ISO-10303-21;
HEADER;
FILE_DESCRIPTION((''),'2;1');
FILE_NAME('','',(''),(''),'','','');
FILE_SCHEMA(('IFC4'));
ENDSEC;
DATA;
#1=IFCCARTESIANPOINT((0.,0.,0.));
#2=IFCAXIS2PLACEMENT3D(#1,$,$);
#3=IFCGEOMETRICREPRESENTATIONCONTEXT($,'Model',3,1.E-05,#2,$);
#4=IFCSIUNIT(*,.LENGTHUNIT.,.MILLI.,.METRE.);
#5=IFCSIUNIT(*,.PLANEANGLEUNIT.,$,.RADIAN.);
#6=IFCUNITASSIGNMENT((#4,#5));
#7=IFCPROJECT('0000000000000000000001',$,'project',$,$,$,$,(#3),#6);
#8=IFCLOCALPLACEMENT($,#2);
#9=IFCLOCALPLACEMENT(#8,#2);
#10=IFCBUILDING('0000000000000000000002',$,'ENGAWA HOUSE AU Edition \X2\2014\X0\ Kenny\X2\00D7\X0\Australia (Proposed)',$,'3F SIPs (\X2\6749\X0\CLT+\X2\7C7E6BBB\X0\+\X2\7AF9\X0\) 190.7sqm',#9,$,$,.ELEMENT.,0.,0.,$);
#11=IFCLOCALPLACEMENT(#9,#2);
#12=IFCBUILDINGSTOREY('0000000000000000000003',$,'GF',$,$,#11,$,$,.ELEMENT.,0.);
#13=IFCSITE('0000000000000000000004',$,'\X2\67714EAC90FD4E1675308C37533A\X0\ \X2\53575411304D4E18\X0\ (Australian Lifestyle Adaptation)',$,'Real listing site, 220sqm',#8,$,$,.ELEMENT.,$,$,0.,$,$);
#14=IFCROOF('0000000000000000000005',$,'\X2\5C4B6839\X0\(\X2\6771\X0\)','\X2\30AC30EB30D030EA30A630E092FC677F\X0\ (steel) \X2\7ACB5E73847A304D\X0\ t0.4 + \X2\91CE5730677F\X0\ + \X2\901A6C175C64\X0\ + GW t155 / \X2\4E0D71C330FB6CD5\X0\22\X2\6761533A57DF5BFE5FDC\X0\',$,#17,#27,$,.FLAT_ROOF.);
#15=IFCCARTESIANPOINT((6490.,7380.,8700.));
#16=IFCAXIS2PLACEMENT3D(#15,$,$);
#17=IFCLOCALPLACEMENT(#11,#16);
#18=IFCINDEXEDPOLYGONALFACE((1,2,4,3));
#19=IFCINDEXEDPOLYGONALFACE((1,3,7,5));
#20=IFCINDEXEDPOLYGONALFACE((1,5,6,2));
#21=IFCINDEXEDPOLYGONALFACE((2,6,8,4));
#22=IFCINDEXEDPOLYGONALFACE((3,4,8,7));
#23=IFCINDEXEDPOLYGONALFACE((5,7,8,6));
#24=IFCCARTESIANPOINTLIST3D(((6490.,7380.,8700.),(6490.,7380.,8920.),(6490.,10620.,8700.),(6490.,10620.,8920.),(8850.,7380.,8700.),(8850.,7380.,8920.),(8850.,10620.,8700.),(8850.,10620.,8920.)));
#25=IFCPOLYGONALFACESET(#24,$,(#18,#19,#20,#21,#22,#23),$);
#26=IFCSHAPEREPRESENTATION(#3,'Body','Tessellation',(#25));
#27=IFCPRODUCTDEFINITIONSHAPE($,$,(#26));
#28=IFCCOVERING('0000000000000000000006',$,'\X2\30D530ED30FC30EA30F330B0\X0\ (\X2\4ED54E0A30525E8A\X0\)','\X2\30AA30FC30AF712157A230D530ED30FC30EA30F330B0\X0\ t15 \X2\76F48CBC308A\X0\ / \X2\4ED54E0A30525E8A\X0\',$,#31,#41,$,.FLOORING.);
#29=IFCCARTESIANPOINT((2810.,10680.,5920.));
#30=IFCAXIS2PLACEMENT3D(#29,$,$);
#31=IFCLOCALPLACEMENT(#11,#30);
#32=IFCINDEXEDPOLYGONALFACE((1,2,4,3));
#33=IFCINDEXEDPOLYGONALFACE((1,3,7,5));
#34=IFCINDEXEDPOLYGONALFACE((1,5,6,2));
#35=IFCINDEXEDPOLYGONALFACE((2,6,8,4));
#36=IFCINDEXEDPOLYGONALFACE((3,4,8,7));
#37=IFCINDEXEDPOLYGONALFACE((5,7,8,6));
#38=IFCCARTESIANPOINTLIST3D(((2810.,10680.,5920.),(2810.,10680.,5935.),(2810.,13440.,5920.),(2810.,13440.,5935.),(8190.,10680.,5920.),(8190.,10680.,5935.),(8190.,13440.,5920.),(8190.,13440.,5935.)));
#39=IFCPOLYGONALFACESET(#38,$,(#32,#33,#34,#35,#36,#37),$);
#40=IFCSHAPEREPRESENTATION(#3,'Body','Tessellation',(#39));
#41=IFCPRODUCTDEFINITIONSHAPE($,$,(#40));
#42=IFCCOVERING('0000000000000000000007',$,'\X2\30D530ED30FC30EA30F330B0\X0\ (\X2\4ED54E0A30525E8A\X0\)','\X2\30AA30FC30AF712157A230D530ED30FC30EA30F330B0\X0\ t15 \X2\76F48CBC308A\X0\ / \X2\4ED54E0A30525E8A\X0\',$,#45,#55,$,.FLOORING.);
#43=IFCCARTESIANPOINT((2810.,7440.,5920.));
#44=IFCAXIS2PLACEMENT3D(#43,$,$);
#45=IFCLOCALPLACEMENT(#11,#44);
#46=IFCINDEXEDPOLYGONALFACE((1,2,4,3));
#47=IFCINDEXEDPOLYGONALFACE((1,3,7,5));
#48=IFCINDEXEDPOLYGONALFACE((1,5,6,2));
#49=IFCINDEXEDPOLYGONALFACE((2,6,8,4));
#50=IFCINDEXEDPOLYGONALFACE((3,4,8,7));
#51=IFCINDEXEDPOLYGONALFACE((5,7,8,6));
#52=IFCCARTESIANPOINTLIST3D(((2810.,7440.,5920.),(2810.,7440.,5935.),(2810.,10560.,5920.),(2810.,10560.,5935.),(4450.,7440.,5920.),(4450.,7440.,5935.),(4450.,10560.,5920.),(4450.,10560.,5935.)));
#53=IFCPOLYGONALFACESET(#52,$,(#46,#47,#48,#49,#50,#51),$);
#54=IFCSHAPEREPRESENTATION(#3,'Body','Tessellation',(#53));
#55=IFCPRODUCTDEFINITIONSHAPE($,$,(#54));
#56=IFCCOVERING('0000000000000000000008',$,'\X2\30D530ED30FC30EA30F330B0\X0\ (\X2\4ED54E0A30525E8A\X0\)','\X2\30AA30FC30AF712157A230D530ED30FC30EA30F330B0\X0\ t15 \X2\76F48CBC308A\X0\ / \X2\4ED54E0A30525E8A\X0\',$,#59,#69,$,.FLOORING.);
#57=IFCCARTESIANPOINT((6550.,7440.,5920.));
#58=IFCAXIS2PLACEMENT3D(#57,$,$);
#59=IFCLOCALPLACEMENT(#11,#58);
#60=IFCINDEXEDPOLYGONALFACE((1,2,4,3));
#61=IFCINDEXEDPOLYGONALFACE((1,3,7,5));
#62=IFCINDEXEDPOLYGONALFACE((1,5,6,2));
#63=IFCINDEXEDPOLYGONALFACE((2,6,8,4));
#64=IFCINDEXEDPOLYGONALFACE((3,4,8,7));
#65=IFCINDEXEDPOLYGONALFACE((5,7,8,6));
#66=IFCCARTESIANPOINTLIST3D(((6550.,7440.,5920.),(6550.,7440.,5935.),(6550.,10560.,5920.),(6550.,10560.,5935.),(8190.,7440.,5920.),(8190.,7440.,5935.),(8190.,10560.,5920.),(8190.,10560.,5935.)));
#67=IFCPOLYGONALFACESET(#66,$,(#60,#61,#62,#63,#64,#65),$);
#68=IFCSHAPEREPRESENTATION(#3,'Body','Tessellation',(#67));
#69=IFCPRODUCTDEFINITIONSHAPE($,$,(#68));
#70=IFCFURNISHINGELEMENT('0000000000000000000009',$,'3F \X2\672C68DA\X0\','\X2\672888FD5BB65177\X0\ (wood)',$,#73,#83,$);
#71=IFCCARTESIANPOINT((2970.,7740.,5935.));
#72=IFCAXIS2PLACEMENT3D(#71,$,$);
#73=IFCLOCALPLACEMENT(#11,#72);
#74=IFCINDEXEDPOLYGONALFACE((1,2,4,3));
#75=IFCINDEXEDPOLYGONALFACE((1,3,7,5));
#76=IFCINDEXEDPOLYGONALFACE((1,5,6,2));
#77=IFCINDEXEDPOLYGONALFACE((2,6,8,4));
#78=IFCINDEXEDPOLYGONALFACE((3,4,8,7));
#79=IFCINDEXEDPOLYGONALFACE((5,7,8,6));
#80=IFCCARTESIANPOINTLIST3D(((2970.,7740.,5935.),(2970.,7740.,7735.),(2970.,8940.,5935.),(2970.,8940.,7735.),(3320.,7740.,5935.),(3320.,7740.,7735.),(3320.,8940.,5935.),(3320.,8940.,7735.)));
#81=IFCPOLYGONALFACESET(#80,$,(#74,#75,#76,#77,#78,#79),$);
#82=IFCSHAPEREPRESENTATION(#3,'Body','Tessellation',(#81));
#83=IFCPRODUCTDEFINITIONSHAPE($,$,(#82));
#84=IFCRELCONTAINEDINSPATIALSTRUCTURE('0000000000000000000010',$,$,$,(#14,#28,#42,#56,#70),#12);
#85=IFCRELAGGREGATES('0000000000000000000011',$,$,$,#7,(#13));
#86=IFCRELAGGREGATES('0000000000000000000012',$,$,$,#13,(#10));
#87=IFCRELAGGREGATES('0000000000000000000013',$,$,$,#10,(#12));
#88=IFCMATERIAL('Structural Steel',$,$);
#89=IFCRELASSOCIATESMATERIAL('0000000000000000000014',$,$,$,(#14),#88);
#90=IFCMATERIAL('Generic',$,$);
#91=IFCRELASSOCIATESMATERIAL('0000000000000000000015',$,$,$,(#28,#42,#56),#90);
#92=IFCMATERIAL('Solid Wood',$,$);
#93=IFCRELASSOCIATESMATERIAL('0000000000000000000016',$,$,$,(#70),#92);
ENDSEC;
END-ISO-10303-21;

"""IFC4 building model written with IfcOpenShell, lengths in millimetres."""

from ifc_helpers import new_model, si_unit, frame, frame_2d, origin, place, context, project, spatial, rectangle, extrude, material, element, save


model = new_model("IFC4")

# Units and contexts
model_context = context("Model", 3, precision=1e-05, world=origin())
ifc_project = project(units=[si_unit("LENGTHUNIT", "METRE", prefix="MILLI"), si_unit("PLANEANGLEUNIT", "RADIAN")], contexts=[model_context])

# Site, building, storey
site_placement = place(None, origin())
site = spatial("IfcSite", under=ifc_project, at=site_placement, Name="東京都世田谷区 南向き丘 (Australian Lifestyle Adaptation)", ObjectType="Real listing site, 220sqm", CompositionType="ELEMENT", RefElevation=0.0)
building_placement = place(site_placement, origin())
building = spatial("IfcBuilding", under=site, at=building_placement, Name="ENGAWA HOUSE AU Edition — Kenny×Australia (Proposed)", ObjectType="3F SIPs (杉CLT+籾殻+竹) 190.7sqm", CompositionType="ELEMENT", ElevationOfRefHeight=0.0, ElevationOfTerrain=0.0)
storey_placement = place(building_placement, origin())
storey = spatial("IfcBuildingStorey", under=building, at=storey_placement, Name="GF", CompositionType="ELEMENT", Elevation=0.0)

# Shared definitions
ifc_material_1 = material(Name="Solid Wood")

# Shared definitions
ifc_material_2 = material(Name="Generic")

# Roof
ifc_material_3 = material(Name="Structural Steel")
roof_1_placement = place(storey_placement, frame((6490.0, 7380.0, 8700.0)))
element("IfcRoof", 1, at=roof_1_placement, inside=storey, material=ifc_material_3, Name="屋根(東)", Description="ガルバリウム鋼板 (steel) 立平葺き t0.4 + 野地板 + 通気層 + GW t155 / 不燃・法22条区域対応", PredefinedType="FLAT_ROOF", context=model_context, shape_type="SweptSolid", body=[
    extrude(rectangle(XDim=2360.0, YDim=3240.0, at=frame_2d((1180.0, 1620.0))), frame((6490.0, 7380.0, 8700.0)), (0.0, 0.0, 1.0), 220.0),
])

# Coverings
covering_1_placement = place(storey_placement, frame((2810.0, 10680.0, 5920.0)))
element("IfcCovering", 2, at=covering_1_placement, inside=storey, material=ifc_material_2, Name="フローリング (仕上げ床)", Description="オーク無垢フローリング t15 直貼り / 仕上げ床", PredefinedType="FLOORING", context=model_context, shape_type="SweptSolid", body=[
    extrude(rectangle(XDim=5380.0, YDim=2760.0, at=frame_2d((2690.0, 1380.0))), frame((2810.0, 10680.0, 5920.0)), (0.0, 0.0, 1.0), 15.0),
])
covering_2_placement = place(storey_placement, frame((2810.0, 7440.0, 5920.0)))
element("IfcCovering", 3, at=covering_2_placement, inside=storey, material=ifc_material_2, Name="フローリング (仕上げ床)", Description="オーク無垢フローリング t15 直貼り / 仕上げ床", PredefinedType="FLOORING", context=model_context, shape_type="SweptSolid", body=[
    extrude(rectangle(XDim=1640.0, YDim=3120.0, at=frame_2d((820.0, 1560.0))), frame((2810.0, 7440.0, 5920.0)), (0.0, 0.0, 1.0), 15.0),
])
covering_3_placement = place(storey_placement, frame((6550.0, 7440.0, 5920.0)))
element("IfcCovering", 4, at=covering_3_placement, inside=storey, material=ifc_material_2, Name="フローリング (仕上げ床)", Description="オーク無垢フローリング t15 直貼り / 仕上げ床", PredefinedType="FLOORING", context=model_context, shape_type="SweptSolid", body=[
    extrude(rectangle(XDim=1640.0, YDim=3120.0, at=frame_2d((820.0, 1560.0))), frame((6550.0, 7440.0, 5920.0)), (0.0, 0.0, 1.0), 15.0),
])

# Furnishing element
furnishing_placement = place(storey_placement, frame((2970.0, 7740.0, 5935.0)))
element("IfcFurnishingElement", 5, at=furnishing_placement, inside=storey, material=ifc_material_1, Name="3F 本棚", Description="木製家具 (wood)", context=model_context, shape_type="SweptSolid", body=[
    extrude(rectangle(XDim=350.0, YDim=1200.0, at=frame_2d((175.0, 600.0))), frame((2970.0, 7740.0, 5935.0)), (0.0, 0.0, 1.0), 1800.0),
])

save(model, "model.ifc")
